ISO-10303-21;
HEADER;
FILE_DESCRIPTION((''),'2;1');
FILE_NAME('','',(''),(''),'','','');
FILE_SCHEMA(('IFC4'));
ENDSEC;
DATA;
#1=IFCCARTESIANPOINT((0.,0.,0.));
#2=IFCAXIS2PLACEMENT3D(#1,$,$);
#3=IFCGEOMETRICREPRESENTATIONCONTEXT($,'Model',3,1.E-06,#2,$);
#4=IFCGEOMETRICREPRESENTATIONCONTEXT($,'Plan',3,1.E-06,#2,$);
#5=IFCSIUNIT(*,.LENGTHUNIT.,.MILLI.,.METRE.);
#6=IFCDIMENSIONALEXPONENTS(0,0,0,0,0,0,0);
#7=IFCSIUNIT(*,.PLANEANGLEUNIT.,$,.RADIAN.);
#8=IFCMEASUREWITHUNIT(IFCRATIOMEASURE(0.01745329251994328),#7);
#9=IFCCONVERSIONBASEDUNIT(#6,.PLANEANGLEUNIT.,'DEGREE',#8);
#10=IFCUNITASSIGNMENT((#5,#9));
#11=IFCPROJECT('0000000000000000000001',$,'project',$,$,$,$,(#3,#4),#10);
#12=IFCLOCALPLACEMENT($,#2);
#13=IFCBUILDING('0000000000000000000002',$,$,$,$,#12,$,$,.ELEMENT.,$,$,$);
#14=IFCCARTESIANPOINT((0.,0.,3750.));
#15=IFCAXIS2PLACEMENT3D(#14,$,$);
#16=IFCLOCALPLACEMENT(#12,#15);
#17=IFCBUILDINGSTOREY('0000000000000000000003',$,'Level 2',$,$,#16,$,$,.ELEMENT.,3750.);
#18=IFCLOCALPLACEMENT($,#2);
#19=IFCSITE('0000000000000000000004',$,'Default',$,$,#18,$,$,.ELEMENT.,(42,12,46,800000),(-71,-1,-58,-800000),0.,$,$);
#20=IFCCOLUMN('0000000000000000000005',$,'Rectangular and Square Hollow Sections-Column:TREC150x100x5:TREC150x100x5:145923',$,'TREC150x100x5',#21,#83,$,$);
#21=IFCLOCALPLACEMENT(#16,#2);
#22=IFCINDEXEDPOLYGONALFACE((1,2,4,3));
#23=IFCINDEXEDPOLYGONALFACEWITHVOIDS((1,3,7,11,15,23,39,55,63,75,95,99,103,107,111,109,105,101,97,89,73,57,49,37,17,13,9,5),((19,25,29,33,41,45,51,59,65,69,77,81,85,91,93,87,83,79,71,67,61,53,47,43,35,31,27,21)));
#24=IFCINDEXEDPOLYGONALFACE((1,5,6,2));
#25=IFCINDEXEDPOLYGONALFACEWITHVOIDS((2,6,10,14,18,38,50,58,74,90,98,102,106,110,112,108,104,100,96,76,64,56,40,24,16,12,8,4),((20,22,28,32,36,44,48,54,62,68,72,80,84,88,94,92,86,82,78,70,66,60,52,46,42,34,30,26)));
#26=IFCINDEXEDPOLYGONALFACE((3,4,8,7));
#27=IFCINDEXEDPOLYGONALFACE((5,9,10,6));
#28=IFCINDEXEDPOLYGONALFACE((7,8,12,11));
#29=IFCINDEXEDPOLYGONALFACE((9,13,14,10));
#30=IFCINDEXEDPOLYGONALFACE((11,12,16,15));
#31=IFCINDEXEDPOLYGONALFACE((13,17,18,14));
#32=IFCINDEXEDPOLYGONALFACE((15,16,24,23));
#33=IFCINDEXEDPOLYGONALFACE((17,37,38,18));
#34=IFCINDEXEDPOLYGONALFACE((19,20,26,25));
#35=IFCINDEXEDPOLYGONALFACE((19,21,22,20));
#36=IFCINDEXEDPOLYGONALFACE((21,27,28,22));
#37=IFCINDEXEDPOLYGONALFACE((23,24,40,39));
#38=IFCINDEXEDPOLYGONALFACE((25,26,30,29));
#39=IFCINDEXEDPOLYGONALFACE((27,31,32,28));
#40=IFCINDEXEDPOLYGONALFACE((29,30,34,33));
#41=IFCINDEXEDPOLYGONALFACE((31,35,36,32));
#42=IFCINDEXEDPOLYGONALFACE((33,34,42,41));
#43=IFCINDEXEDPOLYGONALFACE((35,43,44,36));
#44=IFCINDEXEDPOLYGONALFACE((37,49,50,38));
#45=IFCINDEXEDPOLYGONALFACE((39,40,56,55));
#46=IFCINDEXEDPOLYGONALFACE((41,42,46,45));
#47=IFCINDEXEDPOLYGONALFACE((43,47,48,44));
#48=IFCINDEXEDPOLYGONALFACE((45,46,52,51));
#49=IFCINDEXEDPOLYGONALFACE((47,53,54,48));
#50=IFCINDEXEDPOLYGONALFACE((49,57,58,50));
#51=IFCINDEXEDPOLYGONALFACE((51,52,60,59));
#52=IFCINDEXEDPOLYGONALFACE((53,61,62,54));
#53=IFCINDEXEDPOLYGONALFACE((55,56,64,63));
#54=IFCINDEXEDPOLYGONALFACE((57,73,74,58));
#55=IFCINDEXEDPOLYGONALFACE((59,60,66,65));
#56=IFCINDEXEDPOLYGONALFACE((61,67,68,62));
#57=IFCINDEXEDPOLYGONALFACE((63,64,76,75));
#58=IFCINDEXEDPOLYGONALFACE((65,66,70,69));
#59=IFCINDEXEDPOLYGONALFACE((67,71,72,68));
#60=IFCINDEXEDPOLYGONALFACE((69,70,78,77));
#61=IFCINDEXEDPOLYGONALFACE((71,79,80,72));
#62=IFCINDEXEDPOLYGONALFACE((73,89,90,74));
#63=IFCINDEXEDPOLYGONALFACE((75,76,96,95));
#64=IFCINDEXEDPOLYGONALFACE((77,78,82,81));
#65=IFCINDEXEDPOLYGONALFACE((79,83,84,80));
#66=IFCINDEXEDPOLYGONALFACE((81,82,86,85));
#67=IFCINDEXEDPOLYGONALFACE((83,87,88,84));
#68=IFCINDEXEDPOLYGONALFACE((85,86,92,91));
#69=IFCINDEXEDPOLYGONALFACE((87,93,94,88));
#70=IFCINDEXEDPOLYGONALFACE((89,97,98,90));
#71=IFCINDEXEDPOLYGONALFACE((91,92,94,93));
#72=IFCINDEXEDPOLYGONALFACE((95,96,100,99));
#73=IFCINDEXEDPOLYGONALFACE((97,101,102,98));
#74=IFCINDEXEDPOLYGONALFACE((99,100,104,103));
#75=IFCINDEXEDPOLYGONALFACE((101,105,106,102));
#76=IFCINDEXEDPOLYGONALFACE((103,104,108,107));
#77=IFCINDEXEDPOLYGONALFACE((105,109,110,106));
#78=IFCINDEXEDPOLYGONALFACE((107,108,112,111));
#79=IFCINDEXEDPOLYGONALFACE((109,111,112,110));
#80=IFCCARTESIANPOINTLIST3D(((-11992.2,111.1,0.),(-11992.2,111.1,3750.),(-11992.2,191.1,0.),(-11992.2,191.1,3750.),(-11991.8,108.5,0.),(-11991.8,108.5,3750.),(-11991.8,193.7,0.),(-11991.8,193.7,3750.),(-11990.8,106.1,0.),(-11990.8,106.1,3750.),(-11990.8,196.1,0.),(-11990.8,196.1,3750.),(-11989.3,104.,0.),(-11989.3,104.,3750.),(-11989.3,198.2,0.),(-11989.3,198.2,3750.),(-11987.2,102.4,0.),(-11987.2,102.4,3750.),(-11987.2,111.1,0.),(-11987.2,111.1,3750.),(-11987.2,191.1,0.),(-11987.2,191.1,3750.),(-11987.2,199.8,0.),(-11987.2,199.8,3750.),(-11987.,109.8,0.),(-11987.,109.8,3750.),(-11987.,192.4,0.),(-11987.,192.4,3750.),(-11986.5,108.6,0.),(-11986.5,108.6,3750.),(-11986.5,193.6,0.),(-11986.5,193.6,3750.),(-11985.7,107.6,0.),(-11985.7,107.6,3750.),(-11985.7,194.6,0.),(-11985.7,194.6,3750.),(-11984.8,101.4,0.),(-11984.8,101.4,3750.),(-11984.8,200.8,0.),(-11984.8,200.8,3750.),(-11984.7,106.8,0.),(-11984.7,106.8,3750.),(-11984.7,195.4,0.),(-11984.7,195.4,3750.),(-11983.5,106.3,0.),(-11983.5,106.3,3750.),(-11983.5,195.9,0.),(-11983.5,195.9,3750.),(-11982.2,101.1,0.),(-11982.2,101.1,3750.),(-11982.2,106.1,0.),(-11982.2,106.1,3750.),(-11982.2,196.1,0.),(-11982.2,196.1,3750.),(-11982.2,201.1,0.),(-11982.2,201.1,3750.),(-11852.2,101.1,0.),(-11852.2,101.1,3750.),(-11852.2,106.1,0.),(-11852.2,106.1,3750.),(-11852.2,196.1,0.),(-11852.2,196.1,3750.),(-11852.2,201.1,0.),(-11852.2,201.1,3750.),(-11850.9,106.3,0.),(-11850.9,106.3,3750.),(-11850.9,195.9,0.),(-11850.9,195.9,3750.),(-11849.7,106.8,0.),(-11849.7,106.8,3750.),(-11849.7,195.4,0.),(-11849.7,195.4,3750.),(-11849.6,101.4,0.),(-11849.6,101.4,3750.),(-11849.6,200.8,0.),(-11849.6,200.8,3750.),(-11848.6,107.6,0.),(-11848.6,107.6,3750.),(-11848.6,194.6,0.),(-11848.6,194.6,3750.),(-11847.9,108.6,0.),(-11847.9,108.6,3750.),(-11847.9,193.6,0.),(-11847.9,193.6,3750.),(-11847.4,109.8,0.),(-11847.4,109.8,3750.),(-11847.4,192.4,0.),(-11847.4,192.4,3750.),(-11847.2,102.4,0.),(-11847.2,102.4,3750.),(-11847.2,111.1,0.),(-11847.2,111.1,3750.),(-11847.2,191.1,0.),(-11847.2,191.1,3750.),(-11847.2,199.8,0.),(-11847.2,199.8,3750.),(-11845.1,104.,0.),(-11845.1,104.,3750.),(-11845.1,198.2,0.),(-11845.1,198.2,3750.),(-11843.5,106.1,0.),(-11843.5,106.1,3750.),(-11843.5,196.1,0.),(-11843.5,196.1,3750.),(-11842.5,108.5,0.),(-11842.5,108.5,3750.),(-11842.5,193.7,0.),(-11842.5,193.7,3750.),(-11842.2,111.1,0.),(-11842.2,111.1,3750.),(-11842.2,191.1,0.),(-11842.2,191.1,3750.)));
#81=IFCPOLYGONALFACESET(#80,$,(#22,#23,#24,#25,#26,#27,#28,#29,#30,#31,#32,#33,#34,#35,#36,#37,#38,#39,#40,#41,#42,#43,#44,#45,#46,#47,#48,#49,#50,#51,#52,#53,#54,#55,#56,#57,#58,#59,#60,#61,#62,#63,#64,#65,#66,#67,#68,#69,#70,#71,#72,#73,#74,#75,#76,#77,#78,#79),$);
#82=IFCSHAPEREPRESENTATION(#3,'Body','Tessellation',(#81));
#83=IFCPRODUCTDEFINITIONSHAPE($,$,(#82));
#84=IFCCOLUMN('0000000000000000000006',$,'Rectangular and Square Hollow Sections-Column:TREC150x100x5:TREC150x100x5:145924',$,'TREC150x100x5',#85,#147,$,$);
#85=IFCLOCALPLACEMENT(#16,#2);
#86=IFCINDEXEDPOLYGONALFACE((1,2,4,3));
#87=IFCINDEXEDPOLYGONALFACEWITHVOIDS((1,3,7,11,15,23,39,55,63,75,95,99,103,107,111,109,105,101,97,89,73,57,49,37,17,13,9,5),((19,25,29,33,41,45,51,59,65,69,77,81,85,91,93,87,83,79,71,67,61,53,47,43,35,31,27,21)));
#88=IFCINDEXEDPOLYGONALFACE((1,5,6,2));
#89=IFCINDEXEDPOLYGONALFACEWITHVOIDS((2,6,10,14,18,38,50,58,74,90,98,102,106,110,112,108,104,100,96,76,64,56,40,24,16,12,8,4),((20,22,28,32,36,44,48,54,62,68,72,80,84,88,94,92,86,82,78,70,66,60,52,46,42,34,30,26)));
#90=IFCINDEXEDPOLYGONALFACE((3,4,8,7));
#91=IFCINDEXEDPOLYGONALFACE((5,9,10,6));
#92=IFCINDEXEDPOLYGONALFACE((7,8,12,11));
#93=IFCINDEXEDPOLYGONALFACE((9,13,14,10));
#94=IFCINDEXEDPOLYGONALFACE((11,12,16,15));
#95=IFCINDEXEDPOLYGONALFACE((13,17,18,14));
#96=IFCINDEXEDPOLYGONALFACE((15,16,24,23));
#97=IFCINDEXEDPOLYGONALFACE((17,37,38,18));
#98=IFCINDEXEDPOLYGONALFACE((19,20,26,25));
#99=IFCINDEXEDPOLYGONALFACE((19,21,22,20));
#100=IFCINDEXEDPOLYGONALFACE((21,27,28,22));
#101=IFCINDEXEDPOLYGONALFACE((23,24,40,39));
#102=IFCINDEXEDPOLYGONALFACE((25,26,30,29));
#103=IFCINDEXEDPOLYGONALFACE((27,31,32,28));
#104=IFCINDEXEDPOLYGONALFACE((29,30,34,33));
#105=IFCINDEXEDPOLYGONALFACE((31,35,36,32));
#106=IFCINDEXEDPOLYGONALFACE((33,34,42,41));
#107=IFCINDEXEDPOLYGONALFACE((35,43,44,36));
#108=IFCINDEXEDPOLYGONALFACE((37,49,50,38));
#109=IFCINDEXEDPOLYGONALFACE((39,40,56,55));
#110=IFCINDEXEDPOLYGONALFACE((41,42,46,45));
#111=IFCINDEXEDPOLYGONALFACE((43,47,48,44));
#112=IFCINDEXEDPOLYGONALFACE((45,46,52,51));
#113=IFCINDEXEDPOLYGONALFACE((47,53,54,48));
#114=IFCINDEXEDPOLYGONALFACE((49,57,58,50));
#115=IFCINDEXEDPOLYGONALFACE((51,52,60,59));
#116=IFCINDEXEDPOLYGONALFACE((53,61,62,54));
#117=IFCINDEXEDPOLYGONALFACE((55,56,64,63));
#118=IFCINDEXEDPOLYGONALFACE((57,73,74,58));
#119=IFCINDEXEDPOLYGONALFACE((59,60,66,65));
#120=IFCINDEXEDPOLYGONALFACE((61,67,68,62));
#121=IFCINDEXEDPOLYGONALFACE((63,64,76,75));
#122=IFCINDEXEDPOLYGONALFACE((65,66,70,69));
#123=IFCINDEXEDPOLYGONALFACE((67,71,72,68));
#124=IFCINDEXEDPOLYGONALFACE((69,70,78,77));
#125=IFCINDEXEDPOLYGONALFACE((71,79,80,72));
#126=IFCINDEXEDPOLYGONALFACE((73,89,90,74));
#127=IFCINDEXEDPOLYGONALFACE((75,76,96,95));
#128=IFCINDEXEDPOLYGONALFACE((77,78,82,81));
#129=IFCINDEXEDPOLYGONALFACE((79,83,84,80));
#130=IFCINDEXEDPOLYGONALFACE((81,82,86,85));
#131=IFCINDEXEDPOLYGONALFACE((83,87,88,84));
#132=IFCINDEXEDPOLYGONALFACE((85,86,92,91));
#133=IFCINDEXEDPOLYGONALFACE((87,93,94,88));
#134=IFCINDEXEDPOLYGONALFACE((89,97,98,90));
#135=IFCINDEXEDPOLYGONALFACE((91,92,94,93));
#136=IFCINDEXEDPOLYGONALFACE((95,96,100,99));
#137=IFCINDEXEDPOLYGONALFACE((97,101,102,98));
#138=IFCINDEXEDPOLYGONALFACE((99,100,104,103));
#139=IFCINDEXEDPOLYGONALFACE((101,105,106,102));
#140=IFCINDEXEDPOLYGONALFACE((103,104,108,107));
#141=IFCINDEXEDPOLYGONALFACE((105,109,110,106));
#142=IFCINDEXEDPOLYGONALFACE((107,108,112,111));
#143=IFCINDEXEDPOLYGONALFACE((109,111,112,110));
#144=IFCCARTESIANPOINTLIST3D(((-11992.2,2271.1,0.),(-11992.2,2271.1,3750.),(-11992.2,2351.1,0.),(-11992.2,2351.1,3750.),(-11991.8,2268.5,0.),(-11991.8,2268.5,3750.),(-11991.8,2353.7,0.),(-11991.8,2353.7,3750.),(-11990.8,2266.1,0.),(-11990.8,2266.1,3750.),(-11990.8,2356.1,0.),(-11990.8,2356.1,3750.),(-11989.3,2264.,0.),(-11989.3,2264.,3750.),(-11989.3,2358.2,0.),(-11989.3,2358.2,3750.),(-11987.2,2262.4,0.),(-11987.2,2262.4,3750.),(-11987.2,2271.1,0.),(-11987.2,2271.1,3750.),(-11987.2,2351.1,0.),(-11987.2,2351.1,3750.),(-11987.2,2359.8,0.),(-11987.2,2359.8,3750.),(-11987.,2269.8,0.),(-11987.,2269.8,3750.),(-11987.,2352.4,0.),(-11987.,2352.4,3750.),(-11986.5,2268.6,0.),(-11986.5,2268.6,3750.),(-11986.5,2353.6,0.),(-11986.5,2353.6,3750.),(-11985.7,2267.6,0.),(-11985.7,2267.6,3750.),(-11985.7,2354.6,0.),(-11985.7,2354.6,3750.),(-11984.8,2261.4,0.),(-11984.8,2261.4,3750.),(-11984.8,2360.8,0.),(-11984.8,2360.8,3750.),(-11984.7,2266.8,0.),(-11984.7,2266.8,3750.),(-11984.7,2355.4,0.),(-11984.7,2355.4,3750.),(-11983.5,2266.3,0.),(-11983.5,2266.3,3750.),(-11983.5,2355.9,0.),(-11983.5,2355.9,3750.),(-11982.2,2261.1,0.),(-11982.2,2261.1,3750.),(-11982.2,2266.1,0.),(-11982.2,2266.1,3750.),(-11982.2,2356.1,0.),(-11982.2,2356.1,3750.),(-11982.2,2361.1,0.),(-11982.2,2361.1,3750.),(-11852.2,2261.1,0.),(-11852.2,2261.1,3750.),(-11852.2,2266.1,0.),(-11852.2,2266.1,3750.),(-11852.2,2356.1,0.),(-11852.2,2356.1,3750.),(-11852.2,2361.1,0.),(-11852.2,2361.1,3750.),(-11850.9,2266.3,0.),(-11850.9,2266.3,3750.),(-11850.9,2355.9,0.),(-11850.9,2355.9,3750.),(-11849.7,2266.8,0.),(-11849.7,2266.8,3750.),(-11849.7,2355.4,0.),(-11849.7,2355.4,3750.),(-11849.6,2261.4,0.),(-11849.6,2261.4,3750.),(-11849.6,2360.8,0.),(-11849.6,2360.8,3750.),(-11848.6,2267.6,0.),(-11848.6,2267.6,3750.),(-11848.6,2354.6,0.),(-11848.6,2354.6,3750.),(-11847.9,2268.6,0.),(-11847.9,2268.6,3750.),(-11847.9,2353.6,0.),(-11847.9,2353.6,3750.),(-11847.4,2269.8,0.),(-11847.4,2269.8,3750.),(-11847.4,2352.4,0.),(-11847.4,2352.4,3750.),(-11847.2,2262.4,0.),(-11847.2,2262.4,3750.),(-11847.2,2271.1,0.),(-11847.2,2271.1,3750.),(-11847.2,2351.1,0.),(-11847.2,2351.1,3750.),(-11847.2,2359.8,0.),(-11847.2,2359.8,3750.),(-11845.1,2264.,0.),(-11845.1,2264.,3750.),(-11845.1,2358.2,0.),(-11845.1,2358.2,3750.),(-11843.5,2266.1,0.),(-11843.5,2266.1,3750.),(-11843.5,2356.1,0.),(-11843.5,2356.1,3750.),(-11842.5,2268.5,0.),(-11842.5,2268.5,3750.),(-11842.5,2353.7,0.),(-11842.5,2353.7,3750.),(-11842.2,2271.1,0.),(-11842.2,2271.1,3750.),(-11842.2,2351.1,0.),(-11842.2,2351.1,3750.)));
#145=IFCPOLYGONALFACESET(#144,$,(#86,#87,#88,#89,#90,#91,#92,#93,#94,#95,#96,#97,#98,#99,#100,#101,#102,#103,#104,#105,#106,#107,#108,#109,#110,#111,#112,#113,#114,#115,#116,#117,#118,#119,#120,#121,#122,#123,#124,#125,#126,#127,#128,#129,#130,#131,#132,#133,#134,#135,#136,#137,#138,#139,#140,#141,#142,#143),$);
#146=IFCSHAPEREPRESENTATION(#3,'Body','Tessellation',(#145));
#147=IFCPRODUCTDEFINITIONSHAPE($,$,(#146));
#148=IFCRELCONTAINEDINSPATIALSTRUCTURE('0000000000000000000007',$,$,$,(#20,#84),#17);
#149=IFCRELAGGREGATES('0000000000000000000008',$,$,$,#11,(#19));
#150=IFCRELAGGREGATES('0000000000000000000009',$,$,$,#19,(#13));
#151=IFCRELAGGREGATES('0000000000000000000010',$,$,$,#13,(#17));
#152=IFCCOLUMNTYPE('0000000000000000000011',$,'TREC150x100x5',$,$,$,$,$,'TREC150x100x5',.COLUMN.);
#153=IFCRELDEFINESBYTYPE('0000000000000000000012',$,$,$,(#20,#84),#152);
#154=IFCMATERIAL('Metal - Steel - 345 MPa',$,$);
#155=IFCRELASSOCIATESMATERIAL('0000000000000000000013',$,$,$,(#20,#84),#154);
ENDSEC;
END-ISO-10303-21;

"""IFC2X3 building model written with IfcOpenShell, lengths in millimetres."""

from ifc_helpers import new_model, entity, si_unit, converted_unit, frame, frame_2d, origin, place, context, project, spatial, polyline, circle_curve, parameter, trimmed, segment, composite_curve, outline, extrude, source, transform, mapped, material, type_object, type_shapes, element, save


model = new_model("IFC2X3")

# Units and contexts
model_context = context("Model", 3, precision=1e-06, world=origin())
plan_context = context("Plan", 3, precision=1e-06, world=origin())
ifc_project = project(units=[si_unit("LENGTHUNIT", "METRE", prefix="MILLI"), converted_unit("PLANEANGLEUNIT", "DEGREE", entity("IfcRatioMeasure", 0.01745329251994328), si_unit("PLANEANGLEUNIT", "RADIAN"), dimensions=[0, 0, 0, 0, 0, 0, 0])], contexts=[model_context, plan_context])

# Site, building, storey
site_placement = place(None, origin())
site = spatial("IfcSite", under=ifc_project, at=site_placement, Name="Default", CompositionType="ELEMENT", RefLatitude=(42, 12, 46, 800000), RefLongitude=(-71, -1, -58, -800000), RefElevation=0.0)
building_placement = place(None, origin())
building = spatial("IfcBuilding", under=site, at=building_placement, CompositionType="ELEMENT")
storey_placement = place(building_placement, frame((0.0, 0.0, 3750.0)))
storey = spatial("IfcBuildingStorey", under=building, at=storey_placement, Name="Level 2", CompositionType="ELEMENT", Elevation=3750.0)

# Columns
ifc_material_1 = material(Name="Metal - Steel - 345 MPa")
column_type = type_object("IfcColumnType", Name="TREC150x100x5", ElementType="TREC150x100x5", PredefinedType="COLUMN")
shared_shape = source(origin(), model_context, "Body", "SweptSolid", [
    extrude(outline(composite_curve([segment(polyline([(-40.0, -75.0), (40.0, -75.0)]), True, "CONTINUOUS"), segment(trimmed(circle_curve(frame_2d((40.0, -65.0), x_axis=(-1.0, 0.0)), 10.0), [parameter(90.0)], [parameter(180.0)], True, "PARAMETER"), True, "CONTINUOUS"), segment(polyline([(50.0, -65.0), (50.0, 65.0)]), True, "CONTINUOUS"), segment(trimmed(circle_curve(frame_2d((40.0, 65.0), x_axis=(-1.0, 0.0)), 10.0), [parameter(180.0)], [parameter(270.0)], True, "PARAMETER"), True, "CONTINUOUS"), segment(polyline([(40.0, 75.0), (-40.0, 75.0)]), True, "CONTINUOUS"), segment(trimmed(circle_curve(frame_2d((-40.0, 65.0), x_axis=(-1.0, 0.0)), 10.0), [parameter(270.0)], [parameter(360.0)], True, "PARAMETER"), True, "CONTINUOUS"), segment(polyline([(-50.0, 65.0), (-50.0, -65.0)]), True, "CONTINUOUS"), segment(trimmed(circle_curve(frame_2d((-40.0, -65.0), x_axis=(-1.0, 0.0)), 10.0), [parameter(360.0)], [parameter(90.0)], True, "PARAMETER"), True, "CONTINUOUS")], self_intersect=False), holes=[composite_curve([segment(trimmed(circle_curve(frame_2d((-40.0, -65.0), x_axis=(-1.0, 0.0)), 5.0), [parameter(0.0)], [parameter(90.0)], True, "PARAMETER"), False, "CONTINUOUS"), segment(polyline([(-45.0, -65.0), (-45.0, 65.0)]), True, "CONTINUOUS"), segment(trimmed(circle_curve(frame_2d((-40.0, 65.0), x_axis=(-1.0, 0.0)), 5.0), [parameter(270.0)], [parameter(360.0)], True, "PARAMETER"), False, "CONTINUOUS"), segment(polyline([(-40.0, 70.0), (40.0, 70.0)]), True, "CONTINUOUS"), segment(trimmed(circle_curve(frame_2d((40.0, 65.0), x_axis=(-1.0, 0.0)), 5.0), [parameter(180.0)], [parameter(270.0)], True, "PARAMETER"), False, "CONTINUOUS"), segment(polyline([(45.0, 65.0), (45.0, -65.0)]), True, "CONTINUOUS"), segment(trimmed(circle_curve(frame_2d((40.0, -65.0), x_axis=(-1.0, 0.0)), 5.0), [parameter(90.0)], [parameter(180.0)], True, "PARAMETER"), False, "CONTINUOUS"), segment(polyline([(40.0, -70.0), (-40.0, -70.0)]), True, "CONTINUOUS")], self_intersect=False)]), frame((0.0, 0.0, 3750.0), z_axis=(0.0, 0.0, 1.0), x_axis=(-1.0, 0.0, 0.0)), (0.0, 0.0, 1.0), 3750.0),
])
type_shapes(column_type, [shared_shape])
for number, where, z_axis, x_axis, name in (
    (1, (-11917.2, 151.1, -3750.0), (0.0, 0.0, 1.0), (0.0, 1.0, 0.0), "Rectangular and Square Hollow Sections-Column:TREC150x100x5:TREC150x100x5:145923"),
    (2, (-11917.2, 2311.1, -3750.0), (0.0, 0.0, 1.0), (0.0, 1.0, 0.0), "Rectangular and Square Hollow Sections-Column:TREC150x100x5:TREC150x100x5:145924"),
):
    element("IfcColumn", number, at=place(storey_placement, frame(where, z_axis=z_axis, x_axis=x_axis)), inside=storey, type_object=column_type, material=ifc_material_1, Name=name, ObjectType="TREC150x100x5", context=model_context, shape_type="MappedRepresentation", body=[
        mapped(shared_shape, transform((0.0, 0.0, 0.0), scale=1.0)),
    ])

save(model, "model.ifc")
